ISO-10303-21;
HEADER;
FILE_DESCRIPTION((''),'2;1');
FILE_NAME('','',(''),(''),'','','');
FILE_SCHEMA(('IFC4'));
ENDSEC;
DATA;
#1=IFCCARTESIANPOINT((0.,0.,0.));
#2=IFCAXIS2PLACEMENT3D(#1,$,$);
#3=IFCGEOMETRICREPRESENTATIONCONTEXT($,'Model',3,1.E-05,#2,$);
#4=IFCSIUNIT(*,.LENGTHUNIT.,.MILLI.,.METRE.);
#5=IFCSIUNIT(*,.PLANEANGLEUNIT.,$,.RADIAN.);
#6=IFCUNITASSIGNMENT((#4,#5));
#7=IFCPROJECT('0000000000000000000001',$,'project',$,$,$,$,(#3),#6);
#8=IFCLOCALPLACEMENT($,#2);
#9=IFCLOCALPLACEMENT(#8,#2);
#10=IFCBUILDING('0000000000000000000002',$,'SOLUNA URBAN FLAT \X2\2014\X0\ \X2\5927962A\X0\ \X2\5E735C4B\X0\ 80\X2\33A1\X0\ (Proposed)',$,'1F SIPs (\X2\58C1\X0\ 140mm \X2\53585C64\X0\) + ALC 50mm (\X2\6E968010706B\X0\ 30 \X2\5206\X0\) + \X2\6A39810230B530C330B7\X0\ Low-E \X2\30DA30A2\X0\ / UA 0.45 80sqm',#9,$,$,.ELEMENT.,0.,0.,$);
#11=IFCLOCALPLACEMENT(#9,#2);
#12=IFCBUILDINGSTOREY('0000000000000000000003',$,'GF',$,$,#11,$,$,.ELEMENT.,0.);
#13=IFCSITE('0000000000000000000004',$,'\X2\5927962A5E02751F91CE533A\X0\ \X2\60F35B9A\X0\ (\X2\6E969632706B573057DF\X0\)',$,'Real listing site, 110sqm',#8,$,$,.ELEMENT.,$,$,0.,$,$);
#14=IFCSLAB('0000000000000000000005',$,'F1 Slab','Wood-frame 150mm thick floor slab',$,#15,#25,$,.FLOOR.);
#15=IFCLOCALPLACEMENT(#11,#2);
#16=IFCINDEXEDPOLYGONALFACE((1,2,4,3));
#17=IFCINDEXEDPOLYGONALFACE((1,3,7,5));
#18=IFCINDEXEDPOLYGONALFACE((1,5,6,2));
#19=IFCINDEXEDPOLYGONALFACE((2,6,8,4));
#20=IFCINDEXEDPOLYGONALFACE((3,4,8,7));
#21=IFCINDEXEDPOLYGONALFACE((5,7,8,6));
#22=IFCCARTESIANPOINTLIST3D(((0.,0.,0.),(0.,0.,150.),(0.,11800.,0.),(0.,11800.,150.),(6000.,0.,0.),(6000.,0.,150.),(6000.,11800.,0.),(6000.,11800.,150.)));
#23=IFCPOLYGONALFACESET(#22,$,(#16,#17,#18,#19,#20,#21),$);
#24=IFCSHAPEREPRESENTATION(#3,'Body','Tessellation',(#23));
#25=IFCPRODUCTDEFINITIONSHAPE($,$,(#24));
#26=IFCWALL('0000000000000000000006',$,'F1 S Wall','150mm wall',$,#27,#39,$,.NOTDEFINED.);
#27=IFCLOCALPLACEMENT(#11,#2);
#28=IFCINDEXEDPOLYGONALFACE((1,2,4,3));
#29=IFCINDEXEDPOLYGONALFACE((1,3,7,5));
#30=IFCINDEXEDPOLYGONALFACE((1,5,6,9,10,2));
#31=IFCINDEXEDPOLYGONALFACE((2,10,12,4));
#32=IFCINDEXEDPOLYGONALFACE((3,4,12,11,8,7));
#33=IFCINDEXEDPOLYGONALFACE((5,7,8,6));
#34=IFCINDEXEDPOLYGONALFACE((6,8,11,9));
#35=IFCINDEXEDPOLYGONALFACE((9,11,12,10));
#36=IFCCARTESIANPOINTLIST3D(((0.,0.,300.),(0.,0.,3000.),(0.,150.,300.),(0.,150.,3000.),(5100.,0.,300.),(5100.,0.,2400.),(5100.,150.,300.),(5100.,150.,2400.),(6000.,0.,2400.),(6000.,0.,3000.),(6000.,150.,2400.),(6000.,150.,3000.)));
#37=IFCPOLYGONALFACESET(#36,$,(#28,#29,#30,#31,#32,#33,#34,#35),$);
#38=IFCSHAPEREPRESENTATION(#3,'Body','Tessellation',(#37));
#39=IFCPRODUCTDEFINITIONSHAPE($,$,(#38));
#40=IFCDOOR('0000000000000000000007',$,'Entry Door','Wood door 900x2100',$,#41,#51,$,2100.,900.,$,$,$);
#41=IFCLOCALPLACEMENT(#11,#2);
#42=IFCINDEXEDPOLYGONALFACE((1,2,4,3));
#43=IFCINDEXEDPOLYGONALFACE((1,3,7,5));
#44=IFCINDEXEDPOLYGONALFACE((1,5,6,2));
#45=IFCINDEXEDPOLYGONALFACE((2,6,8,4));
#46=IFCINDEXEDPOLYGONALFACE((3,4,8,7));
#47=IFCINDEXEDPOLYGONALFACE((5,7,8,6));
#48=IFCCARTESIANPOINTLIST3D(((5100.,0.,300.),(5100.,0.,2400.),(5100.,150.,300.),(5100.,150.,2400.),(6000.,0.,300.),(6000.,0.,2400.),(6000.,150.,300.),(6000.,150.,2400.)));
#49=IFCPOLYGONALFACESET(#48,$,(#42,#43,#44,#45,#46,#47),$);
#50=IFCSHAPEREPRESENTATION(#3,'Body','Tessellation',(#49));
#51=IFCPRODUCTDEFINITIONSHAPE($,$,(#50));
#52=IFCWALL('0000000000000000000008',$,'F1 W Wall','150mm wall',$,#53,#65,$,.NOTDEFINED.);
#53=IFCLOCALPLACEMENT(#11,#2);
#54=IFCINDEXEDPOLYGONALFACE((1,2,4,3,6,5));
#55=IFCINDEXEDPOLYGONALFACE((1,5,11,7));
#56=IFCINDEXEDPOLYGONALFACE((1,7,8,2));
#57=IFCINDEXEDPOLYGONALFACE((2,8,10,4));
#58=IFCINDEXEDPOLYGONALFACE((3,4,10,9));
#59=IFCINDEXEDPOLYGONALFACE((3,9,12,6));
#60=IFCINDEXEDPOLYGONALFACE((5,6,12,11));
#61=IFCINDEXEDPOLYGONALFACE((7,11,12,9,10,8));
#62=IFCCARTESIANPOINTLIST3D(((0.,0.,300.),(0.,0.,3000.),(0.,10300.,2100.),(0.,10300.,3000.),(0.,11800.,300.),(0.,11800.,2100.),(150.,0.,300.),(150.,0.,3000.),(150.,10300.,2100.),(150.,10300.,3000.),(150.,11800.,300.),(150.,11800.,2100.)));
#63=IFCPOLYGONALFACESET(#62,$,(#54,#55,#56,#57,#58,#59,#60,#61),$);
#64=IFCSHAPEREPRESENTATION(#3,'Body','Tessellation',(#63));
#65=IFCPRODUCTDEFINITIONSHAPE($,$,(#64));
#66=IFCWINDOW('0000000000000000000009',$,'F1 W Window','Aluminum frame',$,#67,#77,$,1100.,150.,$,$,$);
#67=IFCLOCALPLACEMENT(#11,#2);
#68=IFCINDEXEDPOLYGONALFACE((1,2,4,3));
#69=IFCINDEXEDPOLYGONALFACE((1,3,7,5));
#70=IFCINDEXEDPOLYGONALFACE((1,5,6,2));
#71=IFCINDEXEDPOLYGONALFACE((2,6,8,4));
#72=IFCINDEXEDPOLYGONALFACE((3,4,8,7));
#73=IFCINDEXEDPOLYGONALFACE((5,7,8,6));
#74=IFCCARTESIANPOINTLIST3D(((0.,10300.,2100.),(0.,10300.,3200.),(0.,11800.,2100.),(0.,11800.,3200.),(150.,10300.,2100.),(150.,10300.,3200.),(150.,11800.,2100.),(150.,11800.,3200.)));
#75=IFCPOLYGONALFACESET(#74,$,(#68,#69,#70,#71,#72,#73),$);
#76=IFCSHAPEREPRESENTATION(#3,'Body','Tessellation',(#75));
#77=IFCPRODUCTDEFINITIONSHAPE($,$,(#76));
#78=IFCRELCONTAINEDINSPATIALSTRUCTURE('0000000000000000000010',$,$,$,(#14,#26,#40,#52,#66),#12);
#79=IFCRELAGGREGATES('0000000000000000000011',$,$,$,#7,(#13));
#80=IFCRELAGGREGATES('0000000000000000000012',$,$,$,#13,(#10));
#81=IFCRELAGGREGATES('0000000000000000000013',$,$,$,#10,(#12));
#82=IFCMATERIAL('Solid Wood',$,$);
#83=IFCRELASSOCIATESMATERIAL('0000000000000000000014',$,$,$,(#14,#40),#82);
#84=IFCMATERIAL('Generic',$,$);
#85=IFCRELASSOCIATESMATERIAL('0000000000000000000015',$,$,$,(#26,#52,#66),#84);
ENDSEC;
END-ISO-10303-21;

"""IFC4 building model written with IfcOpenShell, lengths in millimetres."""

from ifc_helpers import new_model, si_unit, frame, frame_2d, origin, place, context, project, spatial, rectangle, extrude, material, element, fill, save


model = new_model("IFC4")

# Units and contexts
model_context = context("Model", 3, precision=1e-05, world=origin())
ifc_project = project(units=[si_unit("LENGTHUNIT", "METRE", prefix="MILLI"), si_unit("PLANEANGLEUNIT", "RADIAN")], contexts=[model_context])

# Site, building, storey
site_placement = place(None, origin())
site = spatial("IfcSite", under=ifc_project, at=site_placement, Name="大阪市生野区 想定 (準防火地域)", ObjectType="Real listing site, 110sqm", CompositionType="ELEMENT", RefElevation=0.0)
building_placement = place(site_placement, origin())
building = spatial("IfcBuilding", under=site, at=building_placement, Name="SOLUNA URBAN FLAT — 大阪 平屋 80㎡ (Proposed)", ObjectType="1F SIPs (壁 140mm 単層) + ALC 50mm (準耐火 30 分) + 樹脂サッシ Low-E ペア / UA 0.45 80sqm", CompositionType="ELEMENT", ElevationOfRefHeight=0.0, ElevationOfTerrain=0.0)
storey_placement = place(building_placement, origin())
storey = spatial("IfcBuildingStorey", under=building, at=storey_placement, Name="GF", CompositionType="ELEMENT", Elevation=0.0)

# Slab
ifc_material_1 = material(Name="Solid Wood")
slab_placement = place(storey_placement, origin())
element("IfcSlab", 1, at=slab_placement, inside=storey, material=ifc_material_1, Name="F1 Slab", Description="Wood-frame 150mm thick floor slab", PredefinedType="FLOOR", context=model_context, shape_type="SweptSolid", body=[
    extrude(rectangle(XDim=6000.0, YDim=11800.0, at=frame_2d((3000.0, 5900.0))), origin(), (0.0, 0.0, 1.0), 150.0),
])

# Shared definitions
ifc_material_2 = material(Name="Generic")

# Wall, opening, door
wall_1_placement = place(storey_placement, frame((0.0, 0.0, 150.0)))
wall_1 = element("IfcWall", 2, at=wall_1_placement, inside=storey, material=ifc_material_2, Name="F1 S Wall", Description="150mm wall", PredefinedType="NOTDEFINED", context=model_context, shape_type="SweptSolid", body=[
    extrude(rectangle(XDim=6000.0, YDim=150.0, at=frame_2d((3000.0, 75.0))), frame((0.0, 0.0, 150.0)), (0.0, 0.0, 1.0), 2700.0),
])
opening_1_placement = place(storey_placement, frame((2550.0, 0.0, 150.0)))
opening_1 = element("IfcOpeningElement", 3, at=opening_1_placement, cuts=wall_1, PredefinedType="NOTDEFINED", context=model_context, shape_type="SweptSolid", body=[
    extrude(rectangle(XDim=900.0, YDim=150.0, at=frame_2d((450.0, 75.0))), frame((2550.0, 0.0, 150.0)), (0.0, 0.0, 1.0), 2100.0),
])
door_placement = place(storey_placement, frame((2550.0, 0.0, 150.0)))
door = element("IfcDoor", 4, at=door_placement, inside=storey, material=ifc_material_1, Name="Entry Door", Description="Wood door 900x2100", OverallHeight=2100.0, OverallWidth=900.0, context=model_context, shape_type="SweptSolid", body=[
    extrude(rectangle(XDim=900.0, YDim=150.0, at=frame_2d((450.0, 75.0))), frame((2550.0, 0.0, 150.0)), (0.0, 0.0, 1.0), 2100.0),
])
fill(opening_1, door)

# Wall, opening, window
wall_2_placement = place(storey_placement, frame((0.0, 0.0, 150.0)))
wall_2 = element("IfcWall", 5, at=wall_2_placement, inside=storey, material=ifc_material_2, Name="F1 W Wall", Description="150mm wall", PredefinedType="NOTDEFINED", context=model_context, shape_type="SweptSolid", body=[
    extrude(rectangle(XDim=150.0, YDim=11800.0, at=frame_2d((75.0, 5900.0))), frame((0.0, 0.0, 150.0)), (0.0, 0.0, 1.0), 2700.0),
])
opening_2_placement = place(storey_placement, frame((0.0, 5150.0, 1050.0)))
opening_2 = element("IfcOpeningElement", 6, at=opening_2_placement, cuts=wall_2, PredefinedType="NOTDEFINED", context=model_context, shape_type="SweptSolid", body=[
    extrude(rectangle(XDim=150.0, YDim=1500.0, at=frame_2d((75.0, 750.0))), frame((0.0, 5150.0, 1050.0)), (0.0, 0.0, 1.0), 1100.0),
])
window_1_placement = place(storey_placement, frame((0.0, 5150.0, 1050.0)))
window_1 = element("IfcWindow", 7, at=window_1_placement, inside=storey, material=ifc_material_2, Name="F1 W Window", Description="Aluminum frame", OverallHeight=1100.0, OverallWidth=150.0, context=model_context, shape_type="SweptSolid", body=[
    extrude(rectangle(XDim=150.0, YDim=1500.0, at=frame_2d((75.0, 750.0))), frame((0.0, 5150.0, 1050.0)), (0.0, 0.0, 1.0), 1100.0),
])
fill(opening_2, window_1)

save(model, "model.ifc")
